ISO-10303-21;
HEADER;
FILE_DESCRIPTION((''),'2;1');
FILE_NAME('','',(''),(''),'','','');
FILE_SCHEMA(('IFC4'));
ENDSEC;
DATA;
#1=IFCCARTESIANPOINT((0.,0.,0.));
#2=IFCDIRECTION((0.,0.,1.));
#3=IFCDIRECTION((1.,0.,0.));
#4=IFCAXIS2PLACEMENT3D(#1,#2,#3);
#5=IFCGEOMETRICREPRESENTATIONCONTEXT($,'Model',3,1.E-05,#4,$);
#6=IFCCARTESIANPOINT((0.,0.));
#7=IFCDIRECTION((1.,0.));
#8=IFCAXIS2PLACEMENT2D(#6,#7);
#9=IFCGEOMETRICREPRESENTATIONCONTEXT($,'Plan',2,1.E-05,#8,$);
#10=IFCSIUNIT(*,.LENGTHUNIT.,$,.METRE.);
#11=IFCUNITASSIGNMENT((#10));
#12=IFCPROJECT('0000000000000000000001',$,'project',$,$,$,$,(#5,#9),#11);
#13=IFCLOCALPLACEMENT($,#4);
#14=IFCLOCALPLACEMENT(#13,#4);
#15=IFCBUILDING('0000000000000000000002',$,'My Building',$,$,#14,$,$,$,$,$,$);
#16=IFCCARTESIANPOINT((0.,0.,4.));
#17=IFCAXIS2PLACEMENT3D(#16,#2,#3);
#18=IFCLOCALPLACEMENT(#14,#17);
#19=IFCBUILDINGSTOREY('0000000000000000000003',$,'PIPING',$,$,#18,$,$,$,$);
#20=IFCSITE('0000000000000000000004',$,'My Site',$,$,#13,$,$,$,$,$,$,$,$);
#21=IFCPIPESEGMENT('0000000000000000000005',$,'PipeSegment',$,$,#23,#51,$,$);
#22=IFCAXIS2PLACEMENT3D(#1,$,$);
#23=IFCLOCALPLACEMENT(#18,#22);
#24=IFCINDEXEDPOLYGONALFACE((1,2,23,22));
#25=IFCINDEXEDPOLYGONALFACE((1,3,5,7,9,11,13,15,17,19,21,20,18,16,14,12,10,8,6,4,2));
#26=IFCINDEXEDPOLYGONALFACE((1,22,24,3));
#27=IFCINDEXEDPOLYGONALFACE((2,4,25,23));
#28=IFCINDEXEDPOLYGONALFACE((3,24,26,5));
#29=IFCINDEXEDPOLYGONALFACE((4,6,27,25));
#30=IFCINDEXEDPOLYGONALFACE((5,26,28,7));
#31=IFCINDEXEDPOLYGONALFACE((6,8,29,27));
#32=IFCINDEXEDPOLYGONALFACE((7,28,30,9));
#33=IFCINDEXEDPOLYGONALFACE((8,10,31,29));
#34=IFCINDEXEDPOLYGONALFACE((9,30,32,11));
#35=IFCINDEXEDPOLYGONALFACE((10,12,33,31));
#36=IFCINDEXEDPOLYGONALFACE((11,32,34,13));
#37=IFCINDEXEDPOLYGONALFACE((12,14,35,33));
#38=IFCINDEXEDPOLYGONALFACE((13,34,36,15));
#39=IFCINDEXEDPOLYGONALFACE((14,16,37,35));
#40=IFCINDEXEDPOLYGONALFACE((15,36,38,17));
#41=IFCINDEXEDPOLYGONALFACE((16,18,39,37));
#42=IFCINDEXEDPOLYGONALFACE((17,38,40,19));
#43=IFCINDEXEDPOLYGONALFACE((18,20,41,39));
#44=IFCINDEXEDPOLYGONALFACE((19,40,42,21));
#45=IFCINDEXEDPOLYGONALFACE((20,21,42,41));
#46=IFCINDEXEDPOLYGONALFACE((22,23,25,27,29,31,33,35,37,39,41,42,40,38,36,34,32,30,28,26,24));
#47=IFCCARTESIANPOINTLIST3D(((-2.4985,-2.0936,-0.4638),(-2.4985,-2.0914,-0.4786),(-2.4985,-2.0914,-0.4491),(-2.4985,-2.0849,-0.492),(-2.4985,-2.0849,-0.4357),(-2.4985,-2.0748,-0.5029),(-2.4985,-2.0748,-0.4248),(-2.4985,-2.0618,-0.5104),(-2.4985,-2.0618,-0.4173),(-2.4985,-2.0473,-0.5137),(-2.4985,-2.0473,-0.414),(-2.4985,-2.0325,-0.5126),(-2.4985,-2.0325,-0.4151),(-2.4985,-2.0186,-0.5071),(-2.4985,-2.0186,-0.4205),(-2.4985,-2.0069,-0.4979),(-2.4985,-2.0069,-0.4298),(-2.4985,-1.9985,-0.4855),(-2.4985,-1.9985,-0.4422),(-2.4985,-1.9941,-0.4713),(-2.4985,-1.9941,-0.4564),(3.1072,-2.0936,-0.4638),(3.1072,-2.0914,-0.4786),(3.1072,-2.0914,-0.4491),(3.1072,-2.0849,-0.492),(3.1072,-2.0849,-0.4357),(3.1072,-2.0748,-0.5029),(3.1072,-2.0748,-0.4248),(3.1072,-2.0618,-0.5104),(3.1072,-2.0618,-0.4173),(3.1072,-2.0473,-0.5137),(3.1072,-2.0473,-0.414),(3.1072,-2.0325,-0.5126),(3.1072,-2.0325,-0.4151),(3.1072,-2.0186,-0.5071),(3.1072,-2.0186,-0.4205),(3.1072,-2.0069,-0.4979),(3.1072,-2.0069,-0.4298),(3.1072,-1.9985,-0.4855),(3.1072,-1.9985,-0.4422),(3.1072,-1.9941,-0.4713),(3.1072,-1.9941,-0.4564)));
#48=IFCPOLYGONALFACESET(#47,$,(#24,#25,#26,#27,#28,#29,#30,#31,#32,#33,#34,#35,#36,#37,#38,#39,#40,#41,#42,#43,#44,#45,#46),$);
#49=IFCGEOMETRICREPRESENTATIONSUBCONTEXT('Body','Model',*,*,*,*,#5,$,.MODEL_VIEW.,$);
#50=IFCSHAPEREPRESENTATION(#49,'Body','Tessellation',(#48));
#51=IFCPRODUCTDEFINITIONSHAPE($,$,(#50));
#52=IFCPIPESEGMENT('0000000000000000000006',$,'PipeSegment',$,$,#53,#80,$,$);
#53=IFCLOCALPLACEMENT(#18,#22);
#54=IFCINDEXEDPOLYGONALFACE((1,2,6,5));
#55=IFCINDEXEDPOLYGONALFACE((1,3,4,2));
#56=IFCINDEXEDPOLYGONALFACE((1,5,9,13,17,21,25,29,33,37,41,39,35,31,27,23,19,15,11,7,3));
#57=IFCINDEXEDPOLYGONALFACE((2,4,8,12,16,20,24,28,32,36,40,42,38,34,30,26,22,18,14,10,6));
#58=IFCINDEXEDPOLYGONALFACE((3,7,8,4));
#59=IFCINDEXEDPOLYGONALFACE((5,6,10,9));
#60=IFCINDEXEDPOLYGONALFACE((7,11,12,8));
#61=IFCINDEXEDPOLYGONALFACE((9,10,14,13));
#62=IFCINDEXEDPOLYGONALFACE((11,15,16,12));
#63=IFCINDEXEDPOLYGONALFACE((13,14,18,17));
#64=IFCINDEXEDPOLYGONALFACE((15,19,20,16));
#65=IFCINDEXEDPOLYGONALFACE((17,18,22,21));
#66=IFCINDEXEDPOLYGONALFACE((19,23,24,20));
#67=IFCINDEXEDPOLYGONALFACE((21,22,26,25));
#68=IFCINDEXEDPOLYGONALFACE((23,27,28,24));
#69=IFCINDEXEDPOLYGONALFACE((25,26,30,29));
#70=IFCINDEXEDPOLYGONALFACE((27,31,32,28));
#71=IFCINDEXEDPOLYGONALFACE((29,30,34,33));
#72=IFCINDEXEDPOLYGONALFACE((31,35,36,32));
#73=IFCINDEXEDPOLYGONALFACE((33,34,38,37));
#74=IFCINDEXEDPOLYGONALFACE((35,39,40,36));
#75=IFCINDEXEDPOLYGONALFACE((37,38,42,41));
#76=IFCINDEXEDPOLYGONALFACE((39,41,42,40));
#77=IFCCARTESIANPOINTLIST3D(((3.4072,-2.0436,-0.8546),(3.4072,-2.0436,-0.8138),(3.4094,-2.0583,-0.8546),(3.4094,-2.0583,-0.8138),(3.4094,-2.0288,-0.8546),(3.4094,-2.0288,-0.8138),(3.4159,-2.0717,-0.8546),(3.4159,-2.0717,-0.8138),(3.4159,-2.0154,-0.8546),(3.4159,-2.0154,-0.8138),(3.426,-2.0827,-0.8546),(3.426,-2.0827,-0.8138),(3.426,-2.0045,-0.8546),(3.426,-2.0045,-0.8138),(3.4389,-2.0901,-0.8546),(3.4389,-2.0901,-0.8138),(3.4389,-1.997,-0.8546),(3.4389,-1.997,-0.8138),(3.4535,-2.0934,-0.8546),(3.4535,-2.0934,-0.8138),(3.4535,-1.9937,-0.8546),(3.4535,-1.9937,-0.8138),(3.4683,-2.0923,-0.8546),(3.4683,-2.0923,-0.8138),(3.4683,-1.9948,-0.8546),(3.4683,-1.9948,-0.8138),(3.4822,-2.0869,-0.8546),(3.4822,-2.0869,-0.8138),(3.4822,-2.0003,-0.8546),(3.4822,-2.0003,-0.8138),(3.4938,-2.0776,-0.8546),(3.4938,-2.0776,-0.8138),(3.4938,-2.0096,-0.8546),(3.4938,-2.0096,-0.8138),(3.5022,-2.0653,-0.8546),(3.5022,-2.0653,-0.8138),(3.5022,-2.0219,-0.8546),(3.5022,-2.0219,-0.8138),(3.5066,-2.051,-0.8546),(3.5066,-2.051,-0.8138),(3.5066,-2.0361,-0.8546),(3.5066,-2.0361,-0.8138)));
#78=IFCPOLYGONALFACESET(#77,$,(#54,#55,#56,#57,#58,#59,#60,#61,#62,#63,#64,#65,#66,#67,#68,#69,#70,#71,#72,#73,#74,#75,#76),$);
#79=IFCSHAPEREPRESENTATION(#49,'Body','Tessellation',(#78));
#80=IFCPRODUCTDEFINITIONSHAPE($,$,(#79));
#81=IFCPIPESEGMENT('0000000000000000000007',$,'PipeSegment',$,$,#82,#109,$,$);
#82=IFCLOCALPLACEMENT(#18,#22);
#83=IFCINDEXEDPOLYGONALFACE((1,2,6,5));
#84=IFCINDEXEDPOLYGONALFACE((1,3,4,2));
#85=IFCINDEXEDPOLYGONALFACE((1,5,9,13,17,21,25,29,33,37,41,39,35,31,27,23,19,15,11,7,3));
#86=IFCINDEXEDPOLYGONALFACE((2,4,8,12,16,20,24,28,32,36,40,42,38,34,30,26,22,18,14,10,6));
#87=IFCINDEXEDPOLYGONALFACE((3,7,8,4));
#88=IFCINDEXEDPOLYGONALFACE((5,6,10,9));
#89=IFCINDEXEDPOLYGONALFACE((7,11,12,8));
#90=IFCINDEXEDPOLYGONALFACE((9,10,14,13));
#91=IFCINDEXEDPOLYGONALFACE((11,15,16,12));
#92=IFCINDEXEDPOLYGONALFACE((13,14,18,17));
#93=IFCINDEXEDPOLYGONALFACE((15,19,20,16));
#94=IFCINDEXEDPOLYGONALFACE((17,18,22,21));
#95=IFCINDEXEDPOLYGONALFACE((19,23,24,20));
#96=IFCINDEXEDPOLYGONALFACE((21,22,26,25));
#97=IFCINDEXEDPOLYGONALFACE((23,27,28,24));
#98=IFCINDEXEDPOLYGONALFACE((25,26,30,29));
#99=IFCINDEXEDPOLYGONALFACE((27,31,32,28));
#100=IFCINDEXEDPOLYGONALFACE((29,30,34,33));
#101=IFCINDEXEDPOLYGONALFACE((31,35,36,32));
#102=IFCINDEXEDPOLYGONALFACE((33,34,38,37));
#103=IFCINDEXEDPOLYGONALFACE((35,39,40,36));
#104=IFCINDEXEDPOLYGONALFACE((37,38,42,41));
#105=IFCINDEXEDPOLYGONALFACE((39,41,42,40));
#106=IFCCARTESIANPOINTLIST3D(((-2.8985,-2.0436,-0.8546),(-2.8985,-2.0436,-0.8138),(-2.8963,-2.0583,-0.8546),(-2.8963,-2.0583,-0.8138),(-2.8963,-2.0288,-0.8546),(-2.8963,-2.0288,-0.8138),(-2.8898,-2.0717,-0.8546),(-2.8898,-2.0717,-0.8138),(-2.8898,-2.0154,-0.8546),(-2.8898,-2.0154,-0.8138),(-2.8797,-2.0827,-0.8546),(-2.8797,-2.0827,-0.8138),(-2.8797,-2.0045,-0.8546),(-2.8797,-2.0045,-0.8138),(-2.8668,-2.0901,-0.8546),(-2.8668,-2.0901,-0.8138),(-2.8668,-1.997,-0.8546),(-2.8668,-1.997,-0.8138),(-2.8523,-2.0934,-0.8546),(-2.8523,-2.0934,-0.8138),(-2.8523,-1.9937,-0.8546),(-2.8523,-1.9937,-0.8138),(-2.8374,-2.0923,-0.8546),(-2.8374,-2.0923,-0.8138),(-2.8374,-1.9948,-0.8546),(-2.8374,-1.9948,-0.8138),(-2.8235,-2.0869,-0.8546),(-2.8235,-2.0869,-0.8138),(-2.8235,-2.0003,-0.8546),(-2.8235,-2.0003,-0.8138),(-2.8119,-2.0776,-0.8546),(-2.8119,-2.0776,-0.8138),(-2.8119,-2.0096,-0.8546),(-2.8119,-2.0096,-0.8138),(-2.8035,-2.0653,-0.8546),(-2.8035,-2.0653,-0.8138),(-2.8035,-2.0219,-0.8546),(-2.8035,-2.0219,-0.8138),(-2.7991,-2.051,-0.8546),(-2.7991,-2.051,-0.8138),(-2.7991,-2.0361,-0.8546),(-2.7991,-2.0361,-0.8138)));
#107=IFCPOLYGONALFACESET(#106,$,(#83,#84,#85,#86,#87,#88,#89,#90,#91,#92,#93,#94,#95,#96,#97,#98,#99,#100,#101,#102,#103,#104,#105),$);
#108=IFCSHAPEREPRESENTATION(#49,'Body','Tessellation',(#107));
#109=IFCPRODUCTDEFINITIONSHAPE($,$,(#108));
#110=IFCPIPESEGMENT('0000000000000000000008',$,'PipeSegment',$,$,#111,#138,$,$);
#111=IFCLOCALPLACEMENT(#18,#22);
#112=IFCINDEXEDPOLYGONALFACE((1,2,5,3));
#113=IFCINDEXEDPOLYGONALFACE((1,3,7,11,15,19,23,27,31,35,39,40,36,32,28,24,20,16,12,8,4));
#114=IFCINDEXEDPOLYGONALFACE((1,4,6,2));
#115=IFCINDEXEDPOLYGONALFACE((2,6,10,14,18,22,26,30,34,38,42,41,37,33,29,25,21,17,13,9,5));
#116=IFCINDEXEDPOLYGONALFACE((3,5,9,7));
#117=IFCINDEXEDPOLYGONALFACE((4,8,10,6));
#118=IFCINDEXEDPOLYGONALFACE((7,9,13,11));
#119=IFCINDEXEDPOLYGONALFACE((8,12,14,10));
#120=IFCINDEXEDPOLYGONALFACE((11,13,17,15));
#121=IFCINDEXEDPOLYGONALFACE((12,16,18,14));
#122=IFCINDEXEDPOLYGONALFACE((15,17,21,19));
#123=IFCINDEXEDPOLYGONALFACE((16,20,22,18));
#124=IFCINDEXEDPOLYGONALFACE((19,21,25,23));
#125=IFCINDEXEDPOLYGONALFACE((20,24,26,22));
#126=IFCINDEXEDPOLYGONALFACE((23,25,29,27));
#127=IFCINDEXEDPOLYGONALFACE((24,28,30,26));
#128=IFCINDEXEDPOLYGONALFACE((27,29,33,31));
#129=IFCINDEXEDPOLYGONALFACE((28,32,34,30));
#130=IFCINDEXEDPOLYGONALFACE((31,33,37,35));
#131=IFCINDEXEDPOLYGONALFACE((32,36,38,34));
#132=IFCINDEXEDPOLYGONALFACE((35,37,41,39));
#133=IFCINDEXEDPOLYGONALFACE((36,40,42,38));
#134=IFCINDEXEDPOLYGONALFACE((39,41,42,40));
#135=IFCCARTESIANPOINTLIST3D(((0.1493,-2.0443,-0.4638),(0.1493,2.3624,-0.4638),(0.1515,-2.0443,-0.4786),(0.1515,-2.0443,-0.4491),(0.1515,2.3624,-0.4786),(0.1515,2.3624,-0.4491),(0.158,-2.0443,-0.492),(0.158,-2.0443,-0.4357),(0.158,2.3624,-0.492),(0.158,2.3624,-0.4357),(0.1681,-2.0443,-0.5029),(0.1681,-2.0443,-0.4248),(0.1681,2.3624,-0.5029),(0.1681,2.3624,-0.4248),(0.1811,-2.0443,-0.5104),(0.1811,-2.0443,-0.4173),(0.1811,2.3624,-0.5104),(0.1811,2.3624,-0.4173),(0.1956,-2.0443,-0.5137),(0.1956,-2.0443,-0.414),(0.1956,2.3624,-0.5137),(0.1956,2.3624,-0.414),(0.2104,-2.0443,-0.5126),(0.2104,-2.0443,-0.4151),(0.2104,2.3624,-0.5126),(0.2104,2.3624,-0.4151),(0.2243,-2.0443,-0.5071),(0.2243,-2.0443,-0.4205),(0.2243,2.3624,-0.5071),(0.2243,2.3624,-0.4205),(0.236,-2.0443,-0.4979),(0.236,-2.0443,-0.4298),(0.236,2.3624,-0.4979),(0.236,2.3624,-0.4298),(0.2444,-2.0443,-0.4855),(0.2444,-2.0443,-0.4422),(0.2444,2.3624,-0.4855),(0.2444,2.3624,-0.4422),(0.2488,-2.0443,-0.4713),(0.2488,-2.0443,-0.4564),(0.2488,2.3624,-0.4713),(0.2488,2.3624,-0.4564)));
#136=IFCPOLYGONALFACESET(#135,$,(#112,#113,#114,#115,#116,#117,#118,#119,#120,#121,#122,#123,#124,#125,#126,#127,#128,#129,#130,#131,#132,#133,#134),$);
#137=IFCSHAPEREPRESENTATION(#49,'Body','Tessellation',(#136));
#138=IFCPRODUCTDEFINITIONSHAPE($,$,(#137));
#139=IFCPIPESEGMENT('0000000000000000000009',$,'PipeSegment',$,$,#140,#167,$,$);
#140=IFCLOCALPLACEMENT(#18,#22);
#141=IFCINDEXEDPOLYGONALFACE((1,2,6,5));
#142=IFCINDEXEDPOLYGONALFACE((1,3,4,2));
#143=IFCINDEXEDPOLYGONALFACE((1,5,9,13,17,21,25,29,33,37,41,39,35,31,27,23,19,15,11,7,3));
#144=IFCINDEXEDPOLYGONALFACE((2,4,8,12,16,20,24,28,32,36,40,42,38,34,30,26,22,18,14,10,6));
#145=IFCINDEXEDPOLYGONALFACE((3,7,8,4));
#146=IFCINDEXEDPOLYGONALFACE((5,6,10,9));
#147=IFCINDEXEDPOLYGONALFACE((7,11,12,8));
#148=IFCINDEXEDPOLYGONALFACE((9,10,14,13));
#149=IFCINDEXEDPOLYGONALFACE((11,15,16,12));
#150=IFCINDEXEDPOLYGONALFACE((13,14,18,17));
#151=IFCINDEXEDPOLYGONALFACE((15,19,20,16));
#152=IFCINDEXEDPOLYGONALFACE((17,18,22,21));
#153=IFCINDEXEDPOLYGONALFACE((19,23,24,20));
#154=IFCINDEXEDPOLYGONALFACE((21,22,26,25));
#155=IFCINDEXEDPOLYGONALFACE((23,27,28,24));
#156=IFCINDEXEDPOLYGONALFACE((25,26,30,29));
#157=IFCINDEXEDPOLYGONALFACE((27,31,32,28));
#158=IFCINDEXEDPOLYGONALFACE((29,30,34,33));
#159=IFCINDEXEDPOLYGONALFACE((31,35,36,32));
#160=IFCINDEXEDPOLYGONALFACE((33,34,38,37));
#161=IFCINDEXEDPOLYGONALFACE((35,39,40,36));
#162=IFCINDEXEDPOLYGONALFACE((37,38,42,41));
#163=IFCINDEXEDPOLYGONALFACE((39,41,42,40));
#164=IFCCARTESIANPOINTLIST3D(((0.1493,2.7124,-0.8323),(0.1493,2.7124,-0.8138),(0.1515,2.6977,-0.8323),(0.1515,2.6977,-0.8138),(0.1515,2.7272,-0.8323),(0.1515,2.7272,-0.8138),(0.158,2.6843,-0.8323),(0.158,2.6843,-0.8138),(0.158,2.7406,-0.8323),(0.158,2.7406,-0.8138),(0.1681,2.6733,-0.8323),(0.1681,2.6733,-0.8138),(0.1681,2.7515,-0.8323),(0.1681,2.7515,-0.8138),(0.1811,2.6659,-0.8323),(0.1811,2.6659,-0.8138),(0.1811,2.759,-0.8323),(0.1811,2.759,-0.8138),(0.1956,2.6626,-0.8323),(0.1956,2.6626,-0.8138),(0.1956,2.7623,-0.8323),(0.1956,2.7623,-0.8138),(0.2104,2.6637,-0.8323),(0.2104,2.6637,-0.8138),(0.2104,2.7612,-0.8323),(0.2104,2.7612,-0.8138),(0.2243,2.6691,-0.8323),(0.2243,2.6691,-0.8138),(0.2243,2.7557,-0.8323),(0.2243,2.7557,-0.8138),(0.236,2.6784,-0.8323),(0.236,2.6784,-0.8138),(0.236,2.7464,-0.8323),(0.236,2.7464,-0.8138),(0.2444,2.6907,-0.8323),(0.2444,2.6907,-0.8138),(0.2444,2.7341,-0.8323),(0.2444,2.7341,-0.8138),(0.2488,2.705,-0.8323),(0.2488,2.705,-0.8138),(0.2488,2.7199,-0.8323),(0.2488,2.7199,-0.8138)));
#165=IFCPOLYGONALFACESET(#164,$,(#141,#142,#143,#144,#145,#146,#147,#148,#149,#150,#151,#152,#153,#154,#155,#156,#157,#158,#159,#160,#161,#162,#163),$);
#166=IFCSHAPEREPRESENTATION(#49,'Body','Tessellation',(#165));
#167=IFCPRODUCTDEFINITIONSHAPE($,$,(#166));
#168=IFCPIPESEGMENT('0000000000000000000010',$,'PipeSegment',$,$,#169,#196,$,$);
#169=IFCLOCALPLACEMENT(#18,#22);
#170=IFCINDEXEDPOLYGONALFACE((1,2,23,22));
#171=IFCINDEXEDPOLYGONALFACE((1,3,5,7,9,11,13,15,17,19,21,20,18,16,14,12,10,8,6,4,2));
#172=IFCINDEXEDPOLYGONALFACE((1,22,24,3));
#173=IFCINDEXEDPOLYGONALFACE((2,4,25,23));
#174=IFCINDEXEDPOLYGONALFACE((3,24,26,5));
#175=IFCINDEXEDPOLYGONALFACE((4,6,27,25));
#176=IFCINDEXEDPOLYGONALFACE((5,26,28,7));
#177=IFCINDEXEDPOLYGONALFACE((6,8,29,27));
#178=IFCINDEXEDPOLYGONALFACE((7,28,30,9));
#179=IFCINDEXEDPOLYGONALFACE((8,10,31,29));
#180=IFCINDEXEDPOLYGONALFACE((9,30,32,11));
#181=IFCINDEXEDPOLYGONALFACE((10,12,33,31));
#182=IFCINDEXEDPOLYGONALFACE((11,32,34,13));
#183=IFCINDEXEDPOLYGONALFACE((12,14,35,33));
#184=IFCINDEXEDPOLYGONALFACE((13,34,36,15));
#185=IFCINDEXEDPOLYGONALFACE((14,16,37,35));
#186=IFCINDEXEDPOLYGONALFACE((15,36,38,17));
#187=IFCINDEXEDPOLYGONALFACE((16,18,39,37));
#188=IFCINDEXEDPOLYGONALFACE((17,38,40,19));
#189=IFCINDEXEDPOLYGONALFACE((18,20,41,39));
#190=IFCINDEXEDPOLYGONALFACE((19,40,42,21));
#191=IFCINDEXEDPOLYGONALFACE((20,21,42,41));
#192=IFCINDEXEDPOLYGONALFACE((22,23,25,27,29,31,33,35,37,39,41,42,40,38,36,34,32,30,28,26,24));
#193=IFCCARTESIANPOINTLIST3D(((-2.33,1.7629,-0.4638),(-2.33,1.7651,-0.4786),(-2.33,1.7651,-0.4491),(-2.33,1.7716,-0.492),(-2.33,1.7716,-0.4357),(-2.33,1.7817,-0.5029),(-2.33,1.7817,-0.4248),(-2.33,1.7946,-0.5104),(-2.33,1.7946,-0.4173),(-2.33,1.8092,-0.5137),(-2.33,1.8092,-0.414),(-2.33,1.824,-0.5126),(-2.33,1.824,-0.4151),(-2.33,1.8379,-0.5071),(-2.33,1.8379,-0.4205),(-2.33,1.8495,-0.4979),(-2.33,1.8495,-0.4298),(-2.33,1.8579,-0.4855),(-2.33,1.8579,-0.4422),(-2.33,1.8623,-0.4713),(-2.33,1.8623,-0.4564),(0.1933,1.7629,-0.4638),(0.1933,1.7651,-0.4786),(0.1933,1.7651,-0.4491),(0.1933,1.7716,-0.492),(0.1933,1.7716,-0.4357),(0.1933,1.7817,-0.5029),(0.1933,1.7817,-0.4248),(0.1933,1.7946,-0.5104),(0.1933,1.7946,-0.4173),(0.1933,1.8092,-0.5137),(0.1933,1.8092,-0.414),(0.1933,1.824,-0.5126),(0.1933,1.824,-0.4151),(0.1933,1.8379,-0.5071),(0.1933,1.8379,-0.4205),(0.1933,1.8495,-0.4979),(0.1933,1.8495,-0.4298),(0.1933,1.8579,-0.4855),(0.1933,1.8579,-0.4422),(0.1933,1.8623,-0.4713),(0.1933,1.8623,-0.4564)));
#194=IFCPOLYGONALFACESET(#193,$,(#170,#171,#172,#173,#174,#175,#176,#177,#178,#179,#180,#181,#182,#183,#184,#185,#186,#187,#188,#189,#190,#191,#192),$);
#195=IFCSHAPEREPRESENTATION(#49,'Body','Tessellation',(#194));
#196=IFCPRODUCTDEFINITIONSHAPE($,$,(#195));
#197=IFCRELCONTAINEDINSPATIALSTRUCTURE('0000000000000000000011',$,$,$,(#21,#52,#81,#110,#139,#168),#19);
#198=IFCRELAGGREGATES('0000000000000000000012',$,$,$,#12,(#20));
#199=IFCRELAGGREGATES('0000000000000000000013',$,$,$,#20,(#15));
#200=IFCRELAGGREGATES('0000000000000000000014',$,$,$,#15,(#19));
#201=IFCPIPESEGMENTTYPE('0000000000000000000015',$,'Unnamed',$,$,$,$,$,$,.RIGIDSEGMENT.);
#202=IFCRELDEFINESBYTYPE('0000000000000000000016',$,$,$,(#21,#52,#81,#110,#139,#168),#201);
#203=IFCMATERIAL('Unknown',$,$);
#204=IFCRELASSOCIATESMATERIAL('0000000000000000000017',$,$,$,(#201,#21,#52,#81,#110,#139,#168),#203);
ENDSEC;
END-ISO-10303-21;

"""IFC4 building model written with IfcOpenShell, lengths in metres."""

from ifc_helpers import new_model, si_unit, frame, origin_with_axes, origin_2d_with_axis, place, context, subcontext, project, spatial, circle, extrude, material, material_profile, profile_set, profile_usage, type_object, element, save


model = new_model("IFC4")

# Units and contexts
model_context = context("Model", 3, precision=1e-05, world=origin_with_axes())
plan_context = context("Plan", 2, precision=1e-05, world=origin_2d_with_axis())
body_context = subcontext(model_context, "Body", "Model", "MODEL_VIEW")
ifc_project = project(units=[si_unit("LENGTHUNIT", "METRE")], contexts=[model_context, plan_context])

# Site, building, storey
site_placement = place(None, origin_with_axes())
site = spatial("IfcSite", under=ifc_project, at=site_placement, Name="My Site")
building_placement = place(site_placement, origin_with_axes())
building = spatial("IfcBuilding", under=site, at=building_placement, Name="My Building")
storey_placement = place(building_placement, frame((0.0, 0.0, 4.0), z_axis=(0.0, 0.0, 1.0), x_axis=(1.0, 0.0, 0.0)))
storey = spatial("IfcBuildingStorey", under=building, at=storey_placement, Name="PIPING")

# Pipe segments
ifc_material = material(Name="Unknown")
ifc_material_profile = material_profile(ifc_material, circle(Radius=0.05))
ifc_profile_set = profile_set([ifc_material_profile])
ifc_profile_usage_1 = profile_usage(ifc_profile_set, cardinal=5)
pipe_segment_type = type_object("IfcPipeSegmentType", Name="Unnamed", PredefinedType="RIGIDSEGMENT", material=ifc_profile_set)
pipe_segment_1_placement = place(storey_placement, frame((3.1072, -2.0436, -0.4638), z_axis=(-1.0, 0.0, 0.0), x_axis=(0.0, -1.0, 0.0)))
element("IfcPipeSegment", 1, at=pipe_segment_1_placement, inside=storey, type_object=pipe_segment_type, material=ifc_profile_usage_1, Name="PipeSegment", context=body_context, shape_type="SweptSolid", body=[
    extrude(circle(Radius=0.05), origin_with_axes(), (0.0, 0.0, 1.0), 5.6057),
])
ifc_profile_usage_2 = profile_usage(ifc_profile_set, cardinal=5)
pipe_segment_2_placement = place(storey_placement, frame((3.4572, -2.0436, -0.8138), z_axis=(0.0, 0.0, -1.0), x_axis=(-1.0, 0.0, 0.0)))
element("IfcPipeSegment", 2, at=pipe_segment_2_placement, inside=storey, type_object=pipe_segment_type, material=ifc_profile_usage_2, Name="PipeSegment", context=body_context, shape_type="SweptSolid", body=[
    extrude(circle(Radius=0.05), origin_with_axes(), (0.0, 0.0, 1.0), 0.0407),
])
ifc_profile_usage_3 = profile_usage(ifc_profile_set, cardinal=5)
pipe_segment_3_placement = place(storey_placement, frame((-2.8485, -2.0436, -0.8138), z_axis=(0.0, 0.0, -1.0), x_axis=(-1.0, 0.0, 0.0)))
element("IfcPipeSegment", 3, at=pipe_segment_3_placement, inside=storey, type_object=pipe_segment_type, material=ifc_profile_usage_3, Name="PipeSegment", context=body_context, shape_type="SweptSolid", body=[
    extrude(circle(Radius=0.05), origin_with_axes(), (0.0, 0.0, 1.0), 0.0407),
])
ifc_profile_usage_4 = profile_usage(ifc_profile_set, cardinal=5)
pipe_segment_4_placement = place(storey_placement, frame((0.1993, -2.0443, -0.4638), z_axis=(0.0, 1.0, 0.0), x_axis=(-1.0, 0.0, 0.0)))
element("IfcPipeSegment", 4, at=pipe_segment_4_placement, inside=storey, type_object=pipe_segment_type, material=ifc_profile_usage_4, Name="PipeSegment", context=body_context, shape_type="SweptSolid", body=[
    extrude(circle(Radius=0.05), origin_with_axes(), (0.0, 0.0, 1.0), 4.4068),
])
ifc_profile_usage_5 = profile_usage(ifc_profile_set, cardinal=5)
pipe_segment_5_placement = place(storey_placement, frame((0.1993, 2.7124, -0.8138), z_axis=(0.0, 0.0, -1.0), x_axis=(-1.0, 0.0, 0.0)))
element("IfcPipeSegment", 5, at=pipe_segment_5_placement, inside=storey, type_object=pipe_segment_type, material=ifc_profile_usage_5, Name="PipeSegment", context=body_context, shape_type="SweptSolid", body=[
    extrude(circle(Radius=0.05), origin_with_axes(), (0.0, 0.0, 1.0), 0.0185),
])
ifc_profile_usage_6 = profile_usage(ifc_profile_set, cardinal=5)
pipe_segment_6_placement = place(storey_placement, frame((0.1933, 1.8129, -0.4638), z_axis=(-1.0, 0.0, 0.0), x_axis=(0.0, -1.0, 0.0)))
element("IfcPipeSegment", 6, at=pipe_segment_6_placement, inside=storey, type_object=pipe_segment_type, material=ifc_profile_usage_6, Name="PipeSegment", context=body_context, shape_type="SweptSolid", body=[
    extrude(circle(Radius=0.05), origin_with_axes(), (0.0, 0.0, 1.0), 2.5233),
])

save(model, "model.ifc")
